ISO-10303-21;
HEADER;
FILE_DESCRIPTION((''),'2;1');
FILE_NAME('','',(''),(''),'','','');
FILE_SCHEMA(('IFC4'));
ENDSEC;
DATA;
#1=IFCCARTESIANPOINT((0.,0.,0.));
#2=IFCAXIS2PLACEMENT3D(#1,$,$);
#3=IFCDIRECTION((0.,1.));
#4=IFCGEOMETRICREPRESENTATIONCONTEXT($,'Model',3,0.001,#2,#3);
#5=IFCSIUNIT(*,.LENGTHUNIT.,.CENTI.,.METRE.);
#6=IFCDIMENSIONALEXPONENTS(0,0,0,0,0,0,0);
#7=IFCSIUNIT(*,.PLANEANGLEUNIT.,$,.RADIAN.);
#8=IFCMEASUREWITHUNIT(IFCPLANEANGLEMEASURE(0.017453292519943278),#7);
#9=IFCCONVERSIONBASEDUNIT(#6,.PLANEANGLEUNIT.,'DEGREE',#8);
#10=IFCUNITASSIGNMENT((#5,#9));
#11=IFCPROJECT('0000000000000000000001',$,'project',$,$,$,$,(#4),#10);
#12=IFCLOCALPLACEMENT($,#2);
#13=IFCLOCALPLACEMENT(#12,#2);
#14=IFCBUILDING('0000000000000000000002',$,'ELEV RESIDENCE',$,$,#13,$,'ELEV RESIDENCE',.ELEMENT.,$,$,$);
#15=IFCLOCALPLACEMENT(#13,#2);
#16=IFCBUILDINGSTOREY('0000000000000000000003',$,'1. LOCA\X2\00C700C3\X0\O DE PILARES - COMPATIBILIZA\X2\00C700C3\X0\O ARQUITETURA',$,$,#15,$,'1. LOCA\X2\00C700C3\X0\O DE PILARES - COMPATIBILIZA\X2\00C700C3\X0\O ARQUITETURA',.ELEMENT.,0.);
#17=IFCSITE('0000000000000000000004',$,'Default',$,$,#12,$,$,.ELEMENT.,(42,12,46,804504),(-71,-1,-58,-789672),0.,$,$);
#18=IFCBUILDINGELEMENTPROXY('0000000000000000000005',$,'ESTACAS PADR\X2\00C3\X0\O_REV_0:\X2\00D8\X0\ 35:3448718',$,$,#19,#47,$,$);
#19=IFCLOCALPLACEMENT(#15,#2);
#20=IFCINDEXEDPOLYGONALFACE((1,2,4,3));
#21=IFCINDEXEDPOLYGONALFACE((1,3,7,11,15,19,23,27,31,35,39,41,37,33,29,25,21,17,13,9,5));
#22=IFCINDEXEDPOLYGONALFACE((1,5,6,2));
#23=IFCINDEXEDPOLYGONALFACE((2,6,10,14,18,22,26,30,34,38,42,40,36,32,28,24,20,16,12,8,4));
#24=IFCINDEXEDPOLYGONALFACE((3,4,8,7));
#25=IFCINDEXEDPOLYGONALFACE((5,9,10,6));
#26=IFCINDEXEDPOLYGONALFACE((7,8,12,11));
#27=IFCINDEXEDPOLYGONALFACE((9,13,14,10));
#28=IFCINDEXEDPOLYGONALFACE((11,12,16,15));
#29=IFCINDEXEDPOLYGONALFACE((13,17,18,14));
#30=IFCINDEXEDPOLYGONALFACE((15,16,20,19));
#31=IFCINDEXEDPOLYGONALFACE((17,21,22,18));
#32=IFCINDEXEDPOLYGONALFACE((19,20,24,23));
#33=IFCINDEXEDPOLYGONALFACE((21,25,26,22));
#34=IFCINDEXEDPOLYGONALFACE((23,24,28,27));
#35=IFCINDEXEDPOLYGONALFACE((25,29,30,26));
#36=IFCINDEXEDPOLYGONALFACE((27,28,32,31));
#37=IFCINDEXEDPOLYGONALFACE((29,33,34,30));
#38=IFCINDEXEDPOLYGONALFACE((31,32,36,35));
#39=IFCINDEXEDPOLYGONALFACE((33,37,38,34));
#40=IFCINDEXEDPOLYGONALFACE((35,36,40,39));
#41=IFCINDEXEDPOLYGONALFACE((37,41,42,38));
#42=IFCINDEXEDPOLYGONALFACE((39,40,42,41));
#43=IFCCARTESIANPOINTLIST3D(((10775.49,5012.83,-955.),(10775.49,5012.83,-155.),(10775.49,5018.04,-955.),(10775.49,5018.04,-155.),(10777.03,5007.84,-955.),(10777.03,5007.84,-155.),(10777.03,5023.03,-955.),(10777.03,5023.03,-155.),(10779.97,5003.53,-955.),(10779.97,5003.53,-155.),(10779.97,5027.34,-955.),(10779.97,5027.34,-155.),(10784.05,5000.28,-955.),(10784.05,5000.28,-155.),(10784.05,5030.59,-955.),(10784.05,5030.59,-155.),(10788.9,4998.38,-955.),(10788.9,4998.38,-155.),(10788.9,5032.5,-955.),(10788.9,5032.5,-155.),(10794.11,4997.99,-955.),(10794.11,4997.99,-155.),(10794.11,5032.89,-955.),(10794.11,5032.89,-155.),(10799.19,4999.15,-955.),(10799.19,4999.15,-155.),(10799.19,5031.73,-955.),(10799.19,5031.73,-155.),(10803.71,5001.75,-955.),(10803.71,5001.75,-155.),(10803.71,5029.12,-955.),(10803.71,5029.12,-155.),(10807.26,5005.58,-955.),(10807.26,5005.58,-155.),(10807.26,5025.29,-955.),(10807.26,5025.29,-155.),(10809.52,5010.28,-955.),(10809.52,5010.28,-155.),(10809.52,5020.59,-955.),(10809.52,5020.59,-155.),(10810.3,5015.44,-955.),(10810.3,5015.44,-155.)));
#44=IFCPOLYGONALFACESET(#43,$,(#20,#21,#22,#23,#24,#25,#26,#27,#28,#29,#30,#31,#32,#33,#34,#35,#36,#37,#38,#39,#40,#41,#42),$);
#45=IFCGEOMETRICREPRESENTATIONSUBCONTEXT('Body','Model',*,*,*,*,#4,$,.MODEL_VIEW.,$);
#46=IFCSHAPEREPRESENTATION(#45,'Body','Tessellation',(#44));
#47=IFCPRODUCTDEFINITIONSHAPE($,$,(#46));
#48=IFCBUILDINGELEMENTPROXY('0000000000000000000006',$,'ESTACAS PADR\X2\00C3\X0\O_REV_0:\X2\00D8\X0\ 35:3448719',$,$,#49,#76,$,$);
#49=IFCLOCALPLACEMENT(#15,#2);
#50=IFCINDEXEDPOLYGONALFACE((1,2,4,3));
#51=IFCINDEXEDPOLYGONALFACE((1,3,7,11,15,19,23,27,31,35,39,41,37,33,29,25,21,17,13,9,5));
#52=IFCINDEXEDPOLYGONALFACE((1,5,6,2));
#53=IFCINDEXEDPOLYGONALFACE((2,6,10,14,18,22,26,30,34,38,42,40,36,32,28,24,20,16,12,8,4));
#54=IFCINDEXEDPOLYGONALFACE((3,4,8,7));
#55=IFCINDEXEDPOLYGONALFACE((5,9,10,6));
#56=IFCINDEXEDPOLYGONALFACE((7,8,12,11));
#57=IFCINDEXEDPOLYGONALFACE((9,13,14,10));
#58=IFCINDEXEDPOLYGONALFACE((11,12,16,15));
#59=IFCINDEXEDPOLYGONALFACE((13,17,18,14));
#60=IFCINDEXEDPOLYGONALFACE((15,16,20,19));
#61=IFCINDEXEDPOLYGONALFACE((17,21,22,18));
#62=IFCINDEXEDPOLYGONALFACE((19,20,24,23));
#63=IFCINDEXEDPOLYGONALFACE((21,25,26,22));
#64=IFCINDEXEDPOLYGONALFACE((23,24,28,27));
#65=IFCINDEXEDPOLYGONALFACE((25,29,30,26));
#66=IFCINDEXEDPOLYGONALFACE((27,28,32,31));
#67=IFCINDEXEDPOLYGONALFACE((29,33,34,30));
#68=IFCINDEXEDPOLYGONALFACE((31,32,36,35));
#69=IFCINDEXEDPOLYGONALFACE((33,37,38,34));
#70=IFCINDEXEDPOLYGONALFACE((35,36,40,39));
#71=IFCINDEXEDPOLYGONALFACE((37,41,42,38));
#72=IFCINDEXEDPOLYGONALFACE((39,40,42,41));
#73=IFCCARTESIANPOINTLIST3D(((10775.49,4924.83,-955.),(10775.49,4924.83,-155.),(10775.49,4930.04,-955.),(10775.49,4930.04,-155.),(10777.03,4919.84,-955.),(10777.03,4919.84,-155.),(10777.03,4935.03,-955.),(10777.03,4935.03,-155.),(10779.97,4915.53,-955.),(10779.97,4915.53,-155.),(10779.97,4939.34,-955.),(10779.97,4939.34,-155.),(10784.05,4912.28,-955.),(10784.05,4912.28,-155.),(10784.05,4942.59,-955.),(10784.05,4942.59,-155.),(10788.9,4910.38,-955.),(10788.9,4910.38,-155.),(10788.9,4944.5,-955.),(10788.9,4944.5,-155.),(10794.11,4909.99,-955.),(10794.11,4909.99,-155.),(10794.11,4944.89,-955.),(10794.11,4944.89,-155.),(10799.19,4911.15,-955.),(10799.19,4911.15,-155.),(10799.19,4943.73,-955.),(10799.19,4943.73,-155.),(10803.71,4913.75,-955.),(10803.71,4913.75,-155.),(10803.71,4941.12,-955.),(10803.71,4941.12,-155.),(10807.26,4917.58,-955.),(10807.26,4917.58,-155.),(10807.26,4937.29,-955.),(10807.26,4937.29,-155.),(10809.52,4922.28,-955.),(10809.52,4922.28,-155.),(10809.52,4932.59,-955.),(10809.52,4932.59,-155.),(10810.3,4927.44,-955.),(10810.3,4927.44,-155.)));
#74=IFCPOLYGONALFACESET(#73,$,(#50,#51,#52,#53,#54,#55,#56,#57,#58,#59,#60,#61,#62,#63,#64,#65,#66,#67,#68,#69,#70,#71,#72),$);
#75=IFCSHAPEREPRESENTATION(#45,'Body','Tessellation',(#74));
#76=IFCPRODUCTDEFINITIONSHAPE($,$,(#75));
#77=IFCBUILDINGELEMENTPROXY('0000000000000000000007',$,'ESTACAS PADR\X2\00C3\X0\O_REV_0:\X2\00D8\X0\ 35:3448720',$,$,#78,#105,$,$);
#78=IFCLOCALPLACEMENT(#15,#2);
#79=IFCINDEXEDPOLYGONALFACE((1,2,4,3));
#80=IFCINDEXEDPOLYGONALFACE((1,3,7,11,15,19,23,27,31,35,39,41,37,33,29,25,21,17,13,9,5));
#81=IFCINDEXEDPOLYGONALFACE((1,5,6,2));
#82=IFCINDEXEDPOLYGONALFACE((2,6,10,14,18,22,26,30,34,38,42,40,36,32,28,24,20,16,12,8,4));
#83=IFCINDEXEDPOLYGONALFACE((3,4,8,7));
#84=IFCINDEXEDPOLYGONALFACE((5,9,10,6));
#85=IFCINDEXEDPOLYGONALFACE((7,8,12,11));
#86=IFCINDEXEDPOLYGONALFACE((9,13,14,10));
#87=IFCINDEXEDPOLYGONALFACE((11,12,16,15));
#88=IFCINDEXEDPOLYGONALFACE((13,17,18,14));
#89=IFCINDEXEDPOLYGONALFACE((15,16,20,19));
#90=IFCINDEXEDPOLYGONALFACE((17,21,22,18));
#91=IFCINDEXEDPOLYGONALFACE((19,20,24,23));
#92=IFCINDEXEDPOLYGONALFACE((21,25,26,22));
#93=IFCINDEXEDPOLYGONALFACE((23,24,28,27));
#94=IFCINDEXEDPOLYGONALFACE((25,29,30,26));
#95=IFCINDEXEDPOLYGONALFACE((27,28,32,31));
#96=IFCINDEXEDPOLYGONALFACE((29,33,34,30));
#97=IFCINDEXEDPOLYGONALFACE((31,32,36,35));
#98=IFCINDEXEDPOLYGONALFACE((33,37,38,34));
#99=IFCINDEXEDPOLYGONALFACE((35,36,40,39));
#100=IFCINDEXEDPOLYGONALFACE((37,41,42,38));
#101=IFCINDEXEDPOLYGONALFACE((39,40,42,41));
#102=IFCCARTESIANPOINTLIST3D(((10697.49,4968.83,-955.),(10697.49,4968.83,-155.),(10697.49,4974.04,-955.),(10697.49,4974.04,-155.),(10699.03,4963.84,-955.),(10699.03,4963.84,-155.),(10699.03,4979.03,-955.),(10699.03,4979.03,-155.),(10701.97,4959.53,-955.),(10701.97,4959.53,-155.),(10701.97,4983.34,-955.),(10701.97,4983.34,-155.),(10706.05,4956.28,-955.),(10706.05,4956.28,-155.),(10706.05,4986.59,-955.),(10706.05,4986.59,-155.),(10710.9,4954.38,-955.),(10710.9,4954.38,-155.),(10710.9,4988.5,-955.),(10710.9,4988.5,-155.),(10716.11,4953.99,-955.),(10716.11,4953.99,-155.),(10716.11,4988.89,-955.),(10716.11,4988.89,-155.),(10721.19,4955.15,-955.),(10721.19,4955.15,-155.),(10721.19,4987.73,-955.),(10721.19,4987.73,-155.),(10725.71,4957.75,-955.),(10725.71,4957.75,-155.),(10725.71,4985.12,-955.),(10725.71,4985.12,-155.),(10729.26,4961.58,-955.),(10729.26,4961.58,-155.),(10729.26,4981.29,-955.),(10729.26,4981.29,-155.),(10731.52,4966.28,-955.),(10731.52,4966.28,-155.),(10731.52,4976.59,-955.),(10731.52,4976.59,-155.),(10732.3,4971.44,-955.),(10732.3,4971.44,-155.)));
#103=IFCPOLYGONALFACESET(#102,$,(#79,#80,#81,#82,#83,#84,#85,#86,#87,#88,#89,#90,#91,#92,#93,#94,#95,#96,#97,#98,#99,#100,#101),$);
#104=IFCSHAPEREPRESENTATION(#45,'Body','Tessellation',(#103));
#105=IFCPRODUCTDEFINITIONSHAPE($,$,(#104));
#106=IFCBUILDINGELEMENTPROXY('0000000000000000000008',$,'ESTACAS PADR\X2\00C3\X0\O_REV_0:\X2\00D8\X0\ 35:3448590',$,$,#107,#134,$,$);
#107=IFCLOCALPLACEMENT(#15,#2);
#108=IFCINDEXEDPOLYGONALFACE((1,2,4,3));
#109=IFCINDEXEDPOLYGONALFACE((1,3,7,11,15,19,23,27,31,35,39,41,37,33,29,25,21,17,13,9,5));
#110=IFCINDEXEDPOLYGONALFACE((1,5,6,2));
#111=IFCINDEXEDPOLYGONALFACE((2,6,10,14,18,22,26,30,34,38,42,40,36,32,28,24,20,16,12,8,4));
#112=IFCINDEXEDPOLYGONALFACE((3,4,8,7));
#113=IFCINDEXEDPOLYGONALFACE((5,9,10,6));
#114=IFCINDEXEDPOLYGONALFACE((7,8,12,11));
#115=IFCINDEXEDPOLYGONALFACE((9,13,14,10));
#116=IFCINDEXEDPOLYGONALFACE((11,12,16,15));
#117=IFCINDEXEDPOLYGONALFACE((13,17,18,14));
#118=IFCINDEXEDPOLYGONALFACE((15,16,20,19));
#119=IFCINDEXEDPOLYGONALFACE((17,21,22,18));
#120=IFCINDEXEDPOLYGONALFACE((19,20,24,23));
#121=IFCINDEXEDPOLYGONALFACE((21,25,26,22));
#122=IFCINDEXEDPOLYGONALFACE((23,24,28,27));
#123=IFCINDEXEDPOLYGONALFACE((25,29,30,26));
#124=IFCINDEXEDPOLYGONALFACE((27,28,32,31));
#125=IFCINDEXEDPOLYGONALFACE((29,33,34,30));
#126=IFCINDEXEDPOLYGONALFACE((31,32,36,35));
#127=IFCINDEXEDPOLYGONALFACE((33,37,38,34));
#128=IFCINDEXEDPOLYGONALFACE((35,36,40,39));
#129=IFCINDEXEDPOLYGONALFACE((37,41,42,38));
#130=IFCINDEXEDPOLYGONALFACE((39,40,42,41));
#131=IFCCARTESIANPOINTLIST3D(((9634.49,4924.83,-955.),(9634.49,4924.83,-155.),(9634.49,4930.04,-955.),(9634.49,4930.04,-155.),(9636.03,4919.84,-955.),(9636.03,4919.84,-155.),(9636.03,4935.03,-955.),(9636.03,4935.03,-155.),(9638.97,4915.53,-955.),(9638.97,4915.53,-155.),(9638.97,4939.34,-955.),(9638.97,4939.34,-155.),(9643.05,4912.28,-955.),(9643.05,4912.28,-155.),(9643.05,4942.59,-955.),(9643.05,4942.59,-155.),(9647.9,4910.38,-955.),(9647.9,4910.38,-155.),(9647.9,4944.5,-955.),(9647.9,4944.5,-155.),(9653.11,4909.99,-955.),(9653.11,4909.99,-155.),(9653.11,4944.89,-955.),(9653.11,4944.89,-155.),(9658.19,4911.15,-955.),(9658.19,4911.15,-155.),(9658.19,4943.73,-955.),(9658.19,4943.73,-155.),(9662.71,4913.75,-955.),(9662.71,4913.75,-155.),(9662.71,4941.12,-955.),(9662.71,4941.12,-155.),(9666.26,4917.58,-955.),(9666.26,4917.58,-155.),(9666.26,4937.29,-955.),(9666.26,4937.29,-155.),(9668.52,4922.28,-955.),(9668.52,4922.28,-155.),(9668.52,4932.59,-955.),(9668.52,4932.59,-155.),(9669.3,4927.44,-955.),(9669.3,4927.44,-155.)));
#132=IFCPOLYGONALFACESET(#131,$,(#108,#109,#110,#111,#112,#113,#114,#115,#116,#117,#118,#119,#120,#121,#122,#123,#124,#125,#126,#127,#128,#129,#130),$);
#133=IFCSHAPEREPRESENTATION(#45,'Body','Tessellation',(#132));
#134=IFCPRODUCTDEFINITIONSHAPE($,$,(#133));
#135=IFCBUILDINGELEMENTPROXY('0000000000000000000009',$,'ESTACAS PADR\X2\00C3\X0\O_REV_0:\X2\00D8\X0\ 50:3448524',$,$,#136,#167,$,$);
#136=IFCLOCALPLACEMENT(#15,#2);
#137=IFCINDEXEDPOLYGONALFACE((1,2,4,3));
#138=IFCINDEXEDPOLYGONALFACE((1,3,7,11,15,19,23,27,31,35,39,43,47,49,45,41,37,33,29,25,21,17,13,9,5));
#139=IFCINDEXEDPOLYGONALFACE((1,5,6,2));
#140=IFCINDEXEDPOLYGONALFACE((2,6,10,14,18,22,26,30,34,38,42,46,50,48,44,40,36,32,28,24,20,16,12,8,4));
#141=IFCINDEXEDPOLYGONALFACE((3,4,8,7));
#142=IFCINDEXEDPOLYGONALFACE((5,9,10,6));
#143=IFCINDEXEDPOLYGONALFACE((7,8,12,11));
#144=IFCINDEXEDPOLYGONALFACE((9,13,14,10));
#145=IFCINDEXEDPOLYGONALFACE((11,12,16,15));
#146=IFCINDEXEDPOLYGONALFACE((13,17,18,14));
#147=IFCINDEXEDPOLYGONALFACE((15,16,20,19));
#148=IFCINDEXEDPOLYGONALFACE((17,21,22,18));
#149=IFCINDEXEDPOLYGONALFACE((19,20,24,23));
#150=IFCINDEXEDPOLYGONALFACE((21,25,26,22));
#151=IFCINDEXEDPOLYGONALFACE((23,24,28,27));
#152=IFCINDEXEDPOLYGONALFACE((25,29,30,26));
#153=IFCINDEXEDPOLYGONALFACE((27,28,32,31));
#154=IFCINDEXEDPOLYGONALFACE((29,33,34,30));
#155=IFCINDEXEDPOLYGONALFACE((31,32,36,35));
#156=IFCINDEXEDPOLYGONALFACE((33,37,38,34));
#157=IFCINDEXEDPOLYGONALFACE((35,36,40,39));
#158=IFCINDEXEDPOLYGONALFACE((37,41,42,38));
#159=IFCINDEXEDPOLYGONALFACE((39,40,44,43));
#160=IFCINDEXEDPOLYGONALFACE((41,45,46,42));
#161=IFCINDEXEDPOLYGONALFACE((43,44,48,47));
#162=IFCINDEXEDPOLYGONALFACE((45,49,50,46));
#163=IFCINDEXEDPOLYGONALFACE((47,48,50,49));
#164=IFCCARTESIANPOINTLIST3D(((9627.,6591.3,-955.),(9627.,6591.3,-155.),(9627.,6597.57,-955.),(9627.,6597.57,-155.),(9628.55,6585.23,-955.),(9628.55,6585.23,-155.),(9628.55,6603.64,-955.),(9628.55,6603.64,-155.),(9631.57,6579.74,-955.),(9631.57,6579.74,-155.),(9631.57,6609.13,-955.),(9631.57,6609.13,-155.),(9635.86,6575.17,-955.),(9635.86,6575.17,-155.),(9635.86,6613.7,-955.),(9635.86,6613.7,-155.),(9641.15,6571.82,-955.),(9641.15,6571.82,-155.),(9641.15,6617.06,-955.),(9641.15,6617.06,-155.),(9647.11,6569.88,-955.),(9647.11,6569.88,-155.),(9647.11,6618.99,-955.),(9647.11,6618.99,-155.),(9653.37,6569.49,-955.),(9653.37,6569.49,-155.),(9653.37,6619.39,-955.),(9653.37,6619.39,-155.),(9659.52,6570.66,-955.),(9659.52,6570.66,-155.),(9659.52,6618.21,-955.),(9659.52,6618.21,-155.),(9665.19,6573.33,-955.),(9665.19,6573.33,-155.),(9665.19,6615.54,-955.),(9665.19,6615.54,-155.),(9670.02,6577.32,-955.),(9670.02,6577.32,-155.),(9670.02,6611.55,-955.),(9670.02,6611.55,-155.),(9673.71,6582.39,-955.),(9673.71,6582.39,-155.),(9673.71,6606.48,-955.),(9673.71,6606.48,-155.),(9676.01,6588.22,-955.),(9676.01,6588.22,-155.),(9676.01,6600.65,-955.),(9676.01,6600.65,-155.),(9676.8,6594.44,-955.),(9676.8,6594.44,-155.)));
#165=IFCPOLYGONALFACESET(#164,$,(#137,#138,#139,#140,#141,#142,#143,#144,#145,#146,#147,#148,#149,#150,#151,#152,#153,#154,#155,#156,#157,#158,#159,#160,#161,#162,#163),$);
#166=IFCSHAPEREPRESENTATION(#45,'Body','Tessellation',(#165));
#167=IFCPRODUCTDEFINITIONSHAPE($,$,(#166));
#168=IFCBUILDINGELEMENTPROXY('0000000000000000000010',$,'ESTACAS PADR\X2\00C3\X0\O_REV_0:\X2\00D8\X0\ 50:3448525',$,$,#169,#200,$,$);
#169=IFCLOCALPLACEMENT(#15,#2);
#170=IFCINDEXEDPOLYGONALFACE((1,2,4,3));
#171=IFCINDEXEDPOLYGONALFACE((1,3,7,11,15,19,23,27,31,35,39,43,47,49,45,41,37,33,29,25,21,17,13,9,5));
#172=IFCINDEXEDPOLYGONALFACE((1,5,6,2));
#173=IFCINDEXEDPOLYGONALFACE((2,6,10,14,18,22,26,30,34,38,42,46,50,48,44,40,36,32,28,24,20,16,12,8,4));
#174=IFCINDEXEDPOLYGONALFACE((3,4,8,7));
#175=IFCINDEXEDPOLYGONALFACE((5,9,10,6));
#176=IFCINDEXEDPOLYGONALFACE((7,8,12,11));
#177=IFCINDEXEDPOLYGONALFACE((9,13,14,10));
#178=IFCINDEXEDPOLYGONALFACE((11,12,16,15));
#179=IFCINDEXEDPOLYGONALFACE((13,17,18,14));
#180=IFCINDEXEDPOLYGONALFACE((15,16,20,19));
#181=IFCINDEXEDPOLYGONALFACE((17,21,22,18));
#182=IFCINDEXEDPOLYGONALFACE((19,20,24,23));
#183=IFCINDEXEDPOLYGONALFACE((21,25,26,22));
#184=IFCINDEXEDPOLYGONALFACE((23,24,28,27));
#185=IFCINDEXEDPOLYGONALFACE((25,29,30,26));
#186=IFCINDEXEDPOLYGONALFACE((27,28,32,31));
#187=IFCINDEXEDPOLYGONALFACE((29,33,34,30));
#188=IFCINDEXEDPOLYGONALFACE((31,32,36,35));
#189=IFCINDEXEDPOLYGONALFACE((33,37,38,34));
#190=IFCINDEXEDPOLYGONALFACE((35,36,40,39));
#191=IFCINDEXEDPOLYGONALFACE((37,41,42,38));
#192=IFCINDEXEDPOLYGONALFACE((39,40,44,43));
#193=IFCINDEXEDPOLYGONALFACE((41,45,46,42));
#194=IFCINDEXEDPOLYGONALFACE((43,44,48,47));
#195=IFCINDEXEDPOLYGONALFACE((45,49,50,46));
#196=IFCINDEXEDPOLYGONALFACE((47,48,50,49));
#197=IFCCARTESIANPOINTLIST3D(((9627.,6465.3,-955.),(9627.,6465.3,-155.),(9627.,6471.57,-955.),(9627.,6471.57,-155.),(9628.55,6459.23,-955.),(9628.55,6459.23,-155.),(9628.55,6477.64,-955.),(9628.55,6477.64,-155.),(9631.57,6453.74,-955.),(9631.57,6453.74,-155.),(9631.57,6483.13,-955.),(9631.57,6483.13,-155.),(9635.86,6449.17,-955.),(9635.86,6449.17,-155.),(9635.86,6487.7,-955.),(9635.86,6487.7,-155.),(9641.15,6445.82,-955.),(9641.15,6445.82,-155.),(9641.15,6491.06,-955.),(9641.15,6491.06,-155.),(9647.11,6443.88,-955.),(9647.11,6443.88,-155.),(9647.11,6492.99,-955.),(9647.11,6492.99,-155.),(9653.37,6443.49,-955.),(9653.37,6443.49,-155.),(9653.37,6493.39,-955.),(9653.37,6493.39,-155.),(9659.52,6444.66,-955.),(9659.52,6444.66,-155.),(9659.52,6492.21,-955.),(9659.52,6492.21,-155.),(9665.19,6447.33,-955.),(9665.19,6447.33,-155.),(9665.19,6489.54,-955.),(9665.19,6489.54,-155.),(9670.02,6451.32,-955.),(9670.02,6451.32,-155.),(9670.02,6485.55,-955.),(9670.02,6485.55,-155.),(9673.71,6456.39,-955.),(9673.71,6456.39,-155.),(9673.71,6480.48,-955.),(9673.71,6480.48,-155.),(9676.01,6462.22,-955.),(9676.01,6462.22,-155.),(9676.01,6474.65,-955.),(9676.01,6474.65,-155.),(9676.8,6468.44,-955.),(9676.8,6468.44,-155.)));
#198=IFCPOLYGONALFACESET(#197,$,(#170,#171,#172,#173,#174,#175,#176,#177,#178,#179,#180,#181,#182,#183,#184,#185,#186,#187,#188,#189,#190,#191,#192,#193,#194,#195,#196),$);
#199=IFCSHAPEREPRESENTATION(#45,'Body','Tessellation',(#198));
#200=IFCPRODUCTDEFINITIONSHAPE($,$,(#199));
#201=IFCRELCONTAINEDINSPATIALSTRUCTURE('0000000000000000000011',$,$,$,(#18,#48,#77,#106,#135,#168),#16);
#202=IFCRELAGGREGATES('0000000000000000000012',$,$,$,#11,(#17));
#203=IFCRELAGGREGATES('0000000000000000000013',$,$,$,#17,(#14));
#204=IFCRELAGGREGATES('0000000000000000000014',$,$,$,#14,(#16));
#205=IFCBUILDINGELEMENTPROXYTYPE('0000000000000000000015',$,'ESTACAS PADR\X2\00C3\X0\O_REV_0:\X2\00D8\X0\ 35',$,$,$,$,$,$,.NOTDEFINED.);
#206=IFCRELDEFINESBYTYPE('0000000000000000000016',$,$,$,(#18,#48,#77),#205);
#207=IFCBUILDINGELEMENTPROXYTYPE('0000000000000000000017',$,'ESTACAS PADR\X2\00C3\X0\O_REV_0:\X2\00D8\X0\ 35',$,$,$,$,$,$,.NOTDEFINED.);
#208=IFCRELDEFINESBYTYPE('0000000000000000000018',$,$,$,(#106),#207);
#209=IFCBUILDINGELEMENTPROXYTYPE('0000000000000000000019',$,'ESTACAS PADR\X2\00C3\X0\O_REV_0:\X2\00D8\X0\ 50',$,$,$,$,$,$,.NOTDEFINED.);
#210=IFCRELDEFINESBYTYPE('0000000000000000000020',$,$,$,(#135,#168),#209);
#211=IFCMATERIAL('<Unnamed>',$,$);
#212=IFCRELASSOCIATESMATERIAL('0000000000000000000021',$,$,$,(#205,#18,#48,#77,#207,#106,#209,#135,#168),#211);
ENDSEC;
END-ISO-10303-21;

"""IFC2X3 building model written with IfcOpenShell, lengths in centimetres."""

from ifc_helpers import new_model, entity, si_unit, converted_unit, direction, frame, frame_2d, origin, place, context, subcontext, project, spatial, circle, extrude, source, transform, mapped, material, type_object, type_shapes, element, save


model = new_model("IFC2X3")

# Units and contexts
model_context = context("Model", 3, precision=0.001, world=origin(), true_north=direction((0.0, 1.0)))
body_context = subcontext(model_context, "Body", "Model", "MODEL_VIEW")
ifc_project = project(units=[si_unit("LENGTHUNIT", "METRE", prefix="CENTI"), converted_unit("PLANEANGLEUNIT", "DEGREE", entity("IfcPlaneAngleMeasure", 0.017453292519943278), si_unit("PLANEANGLEUNIT", "RADIAN"), dimensions=[0, 0, 0, 0, 0, 0, 0])], contexts=[model_context])

# Site, building, storey
site_placement = place(None, origin())
site = spatial("IfcSite", under=ifc_project, at=site_placement, Name="Default", CompositionType="ELEMENT", RefLatitude=(42, 12, 46, 804504), RefLongitude=(-71, -1, -58, -789672), RefElevation=0.0)
building_placement = place(site_placement, origin())
building = spatial("IfcBuilding", under=site, at=building_placement, Name="ELEV RESIDENCE", LongName="ELEV RESIDENCE", CompositionType="ELEMENT")
storey_placement = place(building_placement, origin())
storey = spatial("IfcBuildingStorey", under=building, at=storey_placement, Name="1. LOCAÇÃO DE PILARES - COMPATIBILIZAÇÃO ARQUITETURA", LongName="1. LOCAÇÃO DE PILARES - COMPATIBILIZAÇÃO ARQUITETURA", CompositionType="ELEMENT", Elevation=0.0)

# Building element proxies
ifc_material_1 = material(Name="<Unnamed>")
building_element_proxy_type_1 = type_object("IfcBuildingElementProxyType", Name="ESTACAS PADRÃO_REV_0:Ø 35", PredefinedType="NOTDEFINED", material=ifc_material_1)
shared_shape_1 = source(origin(), body_context, "Body", "SweptSolid", [
    extrude(circle(Radius=17.5, at=frame_2d((0.0, 0.0), x_axis=(1.0, 0.0))), frame((0.0, 0.0, -955.0)), (0.0, 0.0, 1.0), 800.0),
])
type_shapes(building_element_proxy_type_1, [shared_shape_1])
for number, where, name in (
    (1, (10792.8, 5015.44, 0.0), "ESTACAS PADRÃO_REV_0:Ø 35:3448718"),
    (2, (10792.8, 4927.44, 0.0), "ESTACAS PADRÃO_REV_0:Ø 35:3448719"),
    (3, (10714.8, 4971.44, 0.0), "ESTACAS PADRÃO_REV_0:Ø 35:3448720"),
):
    element("IfcBuildingElementProxy", number, at=place(storey_placement, frame(where)), inside=storey, type_object=building_element_proxy_type_1, material=ifc_material_1, Name=name, context=body_context, shape_type="MappedRepresentation", body=[
        mapped(shared_shape_1, transform((0.0, 0.0, 0.0), scale=1.0)),
    ])
building_element_proxy_type_2 = type_object("IfcBuildingElementProxyType", Name="ESTACAS PADRÃO_REV_0:Ø 35", PredefinedType="NOTDEFINED", material=ifc_material_1)
shared_shape_2 = source(origin(), body_context, "Body", "SweptSolid", [
    extrude(circle(Radius=17.5, at=frame_2d((0.0, 0.0), x_axis=(1.0, 0.0))), frame((0.0, 0.0, -955.0)), (0.0, 0.0, 1.0), 800.0),
])
type_shapes(building_element_proxy_type_2, [shared_shape_2])
proxy_placement = place(storey_placement, frame((9651.8, 4927.44, 0.0)))
element("IfcBuildingElementProxy", 4, at=proxy_placement, inside=storey, type_object=building_element_proxy_type_2, material=ifc_material_1, Name="ESTACAS PADRÃO_REV_0:Ø 35:3448590", context=body_context, shape_type="MappedRepresentation", body=[
    mapped(shared_shape_2, transform((0.0, 0.0, 0.0), scale=1.0)),
])
building_element_proxy_type_3 = type_object("IfcBuildingElementProxyType", Name="ESTACAS PADRÃO_REV_0:Ø 50", PredefinedType="NOTDEFINED", material=ifc_material_1)
shared_shape_3 = source(origin(), body_context, "Body", "SweptSolid", [
    extrude(circle(Radius=25.0, at=frame_2d((0.0, 0.0), x_axis=(1.0, 0.0))), frame((0.0, 0.0, -955.0)), (0.0, 0.0, 1.0), 800.0),
])
type_shapes(building_element_proxy_type_3, [shared_shape_3])
for number, where, name in (
    (5, (9651.8, 6594.44, 0.0), "ESTACAS PADRÃO_REV_0:Ø 50:3448524"),
    (6, (9651.8, 6468.44, 0.0), "ESTACAS PADRÃO_REV_0:Ø 50:3448525"),
):
    element("IfcBuildingElementProxy", number, at=place(storey_placement, frame(where)), inside=storey, type_object=building_element_proxy_type_3, material=ifc_material_1, Name=name, context=body_context, shape_type="MappedRepresentation", body=[
        mapped(shared_shape_3, transform((0.0, 0.0, 0.0), scale=1.0)),
    ])

save(model, "model.ifc")
